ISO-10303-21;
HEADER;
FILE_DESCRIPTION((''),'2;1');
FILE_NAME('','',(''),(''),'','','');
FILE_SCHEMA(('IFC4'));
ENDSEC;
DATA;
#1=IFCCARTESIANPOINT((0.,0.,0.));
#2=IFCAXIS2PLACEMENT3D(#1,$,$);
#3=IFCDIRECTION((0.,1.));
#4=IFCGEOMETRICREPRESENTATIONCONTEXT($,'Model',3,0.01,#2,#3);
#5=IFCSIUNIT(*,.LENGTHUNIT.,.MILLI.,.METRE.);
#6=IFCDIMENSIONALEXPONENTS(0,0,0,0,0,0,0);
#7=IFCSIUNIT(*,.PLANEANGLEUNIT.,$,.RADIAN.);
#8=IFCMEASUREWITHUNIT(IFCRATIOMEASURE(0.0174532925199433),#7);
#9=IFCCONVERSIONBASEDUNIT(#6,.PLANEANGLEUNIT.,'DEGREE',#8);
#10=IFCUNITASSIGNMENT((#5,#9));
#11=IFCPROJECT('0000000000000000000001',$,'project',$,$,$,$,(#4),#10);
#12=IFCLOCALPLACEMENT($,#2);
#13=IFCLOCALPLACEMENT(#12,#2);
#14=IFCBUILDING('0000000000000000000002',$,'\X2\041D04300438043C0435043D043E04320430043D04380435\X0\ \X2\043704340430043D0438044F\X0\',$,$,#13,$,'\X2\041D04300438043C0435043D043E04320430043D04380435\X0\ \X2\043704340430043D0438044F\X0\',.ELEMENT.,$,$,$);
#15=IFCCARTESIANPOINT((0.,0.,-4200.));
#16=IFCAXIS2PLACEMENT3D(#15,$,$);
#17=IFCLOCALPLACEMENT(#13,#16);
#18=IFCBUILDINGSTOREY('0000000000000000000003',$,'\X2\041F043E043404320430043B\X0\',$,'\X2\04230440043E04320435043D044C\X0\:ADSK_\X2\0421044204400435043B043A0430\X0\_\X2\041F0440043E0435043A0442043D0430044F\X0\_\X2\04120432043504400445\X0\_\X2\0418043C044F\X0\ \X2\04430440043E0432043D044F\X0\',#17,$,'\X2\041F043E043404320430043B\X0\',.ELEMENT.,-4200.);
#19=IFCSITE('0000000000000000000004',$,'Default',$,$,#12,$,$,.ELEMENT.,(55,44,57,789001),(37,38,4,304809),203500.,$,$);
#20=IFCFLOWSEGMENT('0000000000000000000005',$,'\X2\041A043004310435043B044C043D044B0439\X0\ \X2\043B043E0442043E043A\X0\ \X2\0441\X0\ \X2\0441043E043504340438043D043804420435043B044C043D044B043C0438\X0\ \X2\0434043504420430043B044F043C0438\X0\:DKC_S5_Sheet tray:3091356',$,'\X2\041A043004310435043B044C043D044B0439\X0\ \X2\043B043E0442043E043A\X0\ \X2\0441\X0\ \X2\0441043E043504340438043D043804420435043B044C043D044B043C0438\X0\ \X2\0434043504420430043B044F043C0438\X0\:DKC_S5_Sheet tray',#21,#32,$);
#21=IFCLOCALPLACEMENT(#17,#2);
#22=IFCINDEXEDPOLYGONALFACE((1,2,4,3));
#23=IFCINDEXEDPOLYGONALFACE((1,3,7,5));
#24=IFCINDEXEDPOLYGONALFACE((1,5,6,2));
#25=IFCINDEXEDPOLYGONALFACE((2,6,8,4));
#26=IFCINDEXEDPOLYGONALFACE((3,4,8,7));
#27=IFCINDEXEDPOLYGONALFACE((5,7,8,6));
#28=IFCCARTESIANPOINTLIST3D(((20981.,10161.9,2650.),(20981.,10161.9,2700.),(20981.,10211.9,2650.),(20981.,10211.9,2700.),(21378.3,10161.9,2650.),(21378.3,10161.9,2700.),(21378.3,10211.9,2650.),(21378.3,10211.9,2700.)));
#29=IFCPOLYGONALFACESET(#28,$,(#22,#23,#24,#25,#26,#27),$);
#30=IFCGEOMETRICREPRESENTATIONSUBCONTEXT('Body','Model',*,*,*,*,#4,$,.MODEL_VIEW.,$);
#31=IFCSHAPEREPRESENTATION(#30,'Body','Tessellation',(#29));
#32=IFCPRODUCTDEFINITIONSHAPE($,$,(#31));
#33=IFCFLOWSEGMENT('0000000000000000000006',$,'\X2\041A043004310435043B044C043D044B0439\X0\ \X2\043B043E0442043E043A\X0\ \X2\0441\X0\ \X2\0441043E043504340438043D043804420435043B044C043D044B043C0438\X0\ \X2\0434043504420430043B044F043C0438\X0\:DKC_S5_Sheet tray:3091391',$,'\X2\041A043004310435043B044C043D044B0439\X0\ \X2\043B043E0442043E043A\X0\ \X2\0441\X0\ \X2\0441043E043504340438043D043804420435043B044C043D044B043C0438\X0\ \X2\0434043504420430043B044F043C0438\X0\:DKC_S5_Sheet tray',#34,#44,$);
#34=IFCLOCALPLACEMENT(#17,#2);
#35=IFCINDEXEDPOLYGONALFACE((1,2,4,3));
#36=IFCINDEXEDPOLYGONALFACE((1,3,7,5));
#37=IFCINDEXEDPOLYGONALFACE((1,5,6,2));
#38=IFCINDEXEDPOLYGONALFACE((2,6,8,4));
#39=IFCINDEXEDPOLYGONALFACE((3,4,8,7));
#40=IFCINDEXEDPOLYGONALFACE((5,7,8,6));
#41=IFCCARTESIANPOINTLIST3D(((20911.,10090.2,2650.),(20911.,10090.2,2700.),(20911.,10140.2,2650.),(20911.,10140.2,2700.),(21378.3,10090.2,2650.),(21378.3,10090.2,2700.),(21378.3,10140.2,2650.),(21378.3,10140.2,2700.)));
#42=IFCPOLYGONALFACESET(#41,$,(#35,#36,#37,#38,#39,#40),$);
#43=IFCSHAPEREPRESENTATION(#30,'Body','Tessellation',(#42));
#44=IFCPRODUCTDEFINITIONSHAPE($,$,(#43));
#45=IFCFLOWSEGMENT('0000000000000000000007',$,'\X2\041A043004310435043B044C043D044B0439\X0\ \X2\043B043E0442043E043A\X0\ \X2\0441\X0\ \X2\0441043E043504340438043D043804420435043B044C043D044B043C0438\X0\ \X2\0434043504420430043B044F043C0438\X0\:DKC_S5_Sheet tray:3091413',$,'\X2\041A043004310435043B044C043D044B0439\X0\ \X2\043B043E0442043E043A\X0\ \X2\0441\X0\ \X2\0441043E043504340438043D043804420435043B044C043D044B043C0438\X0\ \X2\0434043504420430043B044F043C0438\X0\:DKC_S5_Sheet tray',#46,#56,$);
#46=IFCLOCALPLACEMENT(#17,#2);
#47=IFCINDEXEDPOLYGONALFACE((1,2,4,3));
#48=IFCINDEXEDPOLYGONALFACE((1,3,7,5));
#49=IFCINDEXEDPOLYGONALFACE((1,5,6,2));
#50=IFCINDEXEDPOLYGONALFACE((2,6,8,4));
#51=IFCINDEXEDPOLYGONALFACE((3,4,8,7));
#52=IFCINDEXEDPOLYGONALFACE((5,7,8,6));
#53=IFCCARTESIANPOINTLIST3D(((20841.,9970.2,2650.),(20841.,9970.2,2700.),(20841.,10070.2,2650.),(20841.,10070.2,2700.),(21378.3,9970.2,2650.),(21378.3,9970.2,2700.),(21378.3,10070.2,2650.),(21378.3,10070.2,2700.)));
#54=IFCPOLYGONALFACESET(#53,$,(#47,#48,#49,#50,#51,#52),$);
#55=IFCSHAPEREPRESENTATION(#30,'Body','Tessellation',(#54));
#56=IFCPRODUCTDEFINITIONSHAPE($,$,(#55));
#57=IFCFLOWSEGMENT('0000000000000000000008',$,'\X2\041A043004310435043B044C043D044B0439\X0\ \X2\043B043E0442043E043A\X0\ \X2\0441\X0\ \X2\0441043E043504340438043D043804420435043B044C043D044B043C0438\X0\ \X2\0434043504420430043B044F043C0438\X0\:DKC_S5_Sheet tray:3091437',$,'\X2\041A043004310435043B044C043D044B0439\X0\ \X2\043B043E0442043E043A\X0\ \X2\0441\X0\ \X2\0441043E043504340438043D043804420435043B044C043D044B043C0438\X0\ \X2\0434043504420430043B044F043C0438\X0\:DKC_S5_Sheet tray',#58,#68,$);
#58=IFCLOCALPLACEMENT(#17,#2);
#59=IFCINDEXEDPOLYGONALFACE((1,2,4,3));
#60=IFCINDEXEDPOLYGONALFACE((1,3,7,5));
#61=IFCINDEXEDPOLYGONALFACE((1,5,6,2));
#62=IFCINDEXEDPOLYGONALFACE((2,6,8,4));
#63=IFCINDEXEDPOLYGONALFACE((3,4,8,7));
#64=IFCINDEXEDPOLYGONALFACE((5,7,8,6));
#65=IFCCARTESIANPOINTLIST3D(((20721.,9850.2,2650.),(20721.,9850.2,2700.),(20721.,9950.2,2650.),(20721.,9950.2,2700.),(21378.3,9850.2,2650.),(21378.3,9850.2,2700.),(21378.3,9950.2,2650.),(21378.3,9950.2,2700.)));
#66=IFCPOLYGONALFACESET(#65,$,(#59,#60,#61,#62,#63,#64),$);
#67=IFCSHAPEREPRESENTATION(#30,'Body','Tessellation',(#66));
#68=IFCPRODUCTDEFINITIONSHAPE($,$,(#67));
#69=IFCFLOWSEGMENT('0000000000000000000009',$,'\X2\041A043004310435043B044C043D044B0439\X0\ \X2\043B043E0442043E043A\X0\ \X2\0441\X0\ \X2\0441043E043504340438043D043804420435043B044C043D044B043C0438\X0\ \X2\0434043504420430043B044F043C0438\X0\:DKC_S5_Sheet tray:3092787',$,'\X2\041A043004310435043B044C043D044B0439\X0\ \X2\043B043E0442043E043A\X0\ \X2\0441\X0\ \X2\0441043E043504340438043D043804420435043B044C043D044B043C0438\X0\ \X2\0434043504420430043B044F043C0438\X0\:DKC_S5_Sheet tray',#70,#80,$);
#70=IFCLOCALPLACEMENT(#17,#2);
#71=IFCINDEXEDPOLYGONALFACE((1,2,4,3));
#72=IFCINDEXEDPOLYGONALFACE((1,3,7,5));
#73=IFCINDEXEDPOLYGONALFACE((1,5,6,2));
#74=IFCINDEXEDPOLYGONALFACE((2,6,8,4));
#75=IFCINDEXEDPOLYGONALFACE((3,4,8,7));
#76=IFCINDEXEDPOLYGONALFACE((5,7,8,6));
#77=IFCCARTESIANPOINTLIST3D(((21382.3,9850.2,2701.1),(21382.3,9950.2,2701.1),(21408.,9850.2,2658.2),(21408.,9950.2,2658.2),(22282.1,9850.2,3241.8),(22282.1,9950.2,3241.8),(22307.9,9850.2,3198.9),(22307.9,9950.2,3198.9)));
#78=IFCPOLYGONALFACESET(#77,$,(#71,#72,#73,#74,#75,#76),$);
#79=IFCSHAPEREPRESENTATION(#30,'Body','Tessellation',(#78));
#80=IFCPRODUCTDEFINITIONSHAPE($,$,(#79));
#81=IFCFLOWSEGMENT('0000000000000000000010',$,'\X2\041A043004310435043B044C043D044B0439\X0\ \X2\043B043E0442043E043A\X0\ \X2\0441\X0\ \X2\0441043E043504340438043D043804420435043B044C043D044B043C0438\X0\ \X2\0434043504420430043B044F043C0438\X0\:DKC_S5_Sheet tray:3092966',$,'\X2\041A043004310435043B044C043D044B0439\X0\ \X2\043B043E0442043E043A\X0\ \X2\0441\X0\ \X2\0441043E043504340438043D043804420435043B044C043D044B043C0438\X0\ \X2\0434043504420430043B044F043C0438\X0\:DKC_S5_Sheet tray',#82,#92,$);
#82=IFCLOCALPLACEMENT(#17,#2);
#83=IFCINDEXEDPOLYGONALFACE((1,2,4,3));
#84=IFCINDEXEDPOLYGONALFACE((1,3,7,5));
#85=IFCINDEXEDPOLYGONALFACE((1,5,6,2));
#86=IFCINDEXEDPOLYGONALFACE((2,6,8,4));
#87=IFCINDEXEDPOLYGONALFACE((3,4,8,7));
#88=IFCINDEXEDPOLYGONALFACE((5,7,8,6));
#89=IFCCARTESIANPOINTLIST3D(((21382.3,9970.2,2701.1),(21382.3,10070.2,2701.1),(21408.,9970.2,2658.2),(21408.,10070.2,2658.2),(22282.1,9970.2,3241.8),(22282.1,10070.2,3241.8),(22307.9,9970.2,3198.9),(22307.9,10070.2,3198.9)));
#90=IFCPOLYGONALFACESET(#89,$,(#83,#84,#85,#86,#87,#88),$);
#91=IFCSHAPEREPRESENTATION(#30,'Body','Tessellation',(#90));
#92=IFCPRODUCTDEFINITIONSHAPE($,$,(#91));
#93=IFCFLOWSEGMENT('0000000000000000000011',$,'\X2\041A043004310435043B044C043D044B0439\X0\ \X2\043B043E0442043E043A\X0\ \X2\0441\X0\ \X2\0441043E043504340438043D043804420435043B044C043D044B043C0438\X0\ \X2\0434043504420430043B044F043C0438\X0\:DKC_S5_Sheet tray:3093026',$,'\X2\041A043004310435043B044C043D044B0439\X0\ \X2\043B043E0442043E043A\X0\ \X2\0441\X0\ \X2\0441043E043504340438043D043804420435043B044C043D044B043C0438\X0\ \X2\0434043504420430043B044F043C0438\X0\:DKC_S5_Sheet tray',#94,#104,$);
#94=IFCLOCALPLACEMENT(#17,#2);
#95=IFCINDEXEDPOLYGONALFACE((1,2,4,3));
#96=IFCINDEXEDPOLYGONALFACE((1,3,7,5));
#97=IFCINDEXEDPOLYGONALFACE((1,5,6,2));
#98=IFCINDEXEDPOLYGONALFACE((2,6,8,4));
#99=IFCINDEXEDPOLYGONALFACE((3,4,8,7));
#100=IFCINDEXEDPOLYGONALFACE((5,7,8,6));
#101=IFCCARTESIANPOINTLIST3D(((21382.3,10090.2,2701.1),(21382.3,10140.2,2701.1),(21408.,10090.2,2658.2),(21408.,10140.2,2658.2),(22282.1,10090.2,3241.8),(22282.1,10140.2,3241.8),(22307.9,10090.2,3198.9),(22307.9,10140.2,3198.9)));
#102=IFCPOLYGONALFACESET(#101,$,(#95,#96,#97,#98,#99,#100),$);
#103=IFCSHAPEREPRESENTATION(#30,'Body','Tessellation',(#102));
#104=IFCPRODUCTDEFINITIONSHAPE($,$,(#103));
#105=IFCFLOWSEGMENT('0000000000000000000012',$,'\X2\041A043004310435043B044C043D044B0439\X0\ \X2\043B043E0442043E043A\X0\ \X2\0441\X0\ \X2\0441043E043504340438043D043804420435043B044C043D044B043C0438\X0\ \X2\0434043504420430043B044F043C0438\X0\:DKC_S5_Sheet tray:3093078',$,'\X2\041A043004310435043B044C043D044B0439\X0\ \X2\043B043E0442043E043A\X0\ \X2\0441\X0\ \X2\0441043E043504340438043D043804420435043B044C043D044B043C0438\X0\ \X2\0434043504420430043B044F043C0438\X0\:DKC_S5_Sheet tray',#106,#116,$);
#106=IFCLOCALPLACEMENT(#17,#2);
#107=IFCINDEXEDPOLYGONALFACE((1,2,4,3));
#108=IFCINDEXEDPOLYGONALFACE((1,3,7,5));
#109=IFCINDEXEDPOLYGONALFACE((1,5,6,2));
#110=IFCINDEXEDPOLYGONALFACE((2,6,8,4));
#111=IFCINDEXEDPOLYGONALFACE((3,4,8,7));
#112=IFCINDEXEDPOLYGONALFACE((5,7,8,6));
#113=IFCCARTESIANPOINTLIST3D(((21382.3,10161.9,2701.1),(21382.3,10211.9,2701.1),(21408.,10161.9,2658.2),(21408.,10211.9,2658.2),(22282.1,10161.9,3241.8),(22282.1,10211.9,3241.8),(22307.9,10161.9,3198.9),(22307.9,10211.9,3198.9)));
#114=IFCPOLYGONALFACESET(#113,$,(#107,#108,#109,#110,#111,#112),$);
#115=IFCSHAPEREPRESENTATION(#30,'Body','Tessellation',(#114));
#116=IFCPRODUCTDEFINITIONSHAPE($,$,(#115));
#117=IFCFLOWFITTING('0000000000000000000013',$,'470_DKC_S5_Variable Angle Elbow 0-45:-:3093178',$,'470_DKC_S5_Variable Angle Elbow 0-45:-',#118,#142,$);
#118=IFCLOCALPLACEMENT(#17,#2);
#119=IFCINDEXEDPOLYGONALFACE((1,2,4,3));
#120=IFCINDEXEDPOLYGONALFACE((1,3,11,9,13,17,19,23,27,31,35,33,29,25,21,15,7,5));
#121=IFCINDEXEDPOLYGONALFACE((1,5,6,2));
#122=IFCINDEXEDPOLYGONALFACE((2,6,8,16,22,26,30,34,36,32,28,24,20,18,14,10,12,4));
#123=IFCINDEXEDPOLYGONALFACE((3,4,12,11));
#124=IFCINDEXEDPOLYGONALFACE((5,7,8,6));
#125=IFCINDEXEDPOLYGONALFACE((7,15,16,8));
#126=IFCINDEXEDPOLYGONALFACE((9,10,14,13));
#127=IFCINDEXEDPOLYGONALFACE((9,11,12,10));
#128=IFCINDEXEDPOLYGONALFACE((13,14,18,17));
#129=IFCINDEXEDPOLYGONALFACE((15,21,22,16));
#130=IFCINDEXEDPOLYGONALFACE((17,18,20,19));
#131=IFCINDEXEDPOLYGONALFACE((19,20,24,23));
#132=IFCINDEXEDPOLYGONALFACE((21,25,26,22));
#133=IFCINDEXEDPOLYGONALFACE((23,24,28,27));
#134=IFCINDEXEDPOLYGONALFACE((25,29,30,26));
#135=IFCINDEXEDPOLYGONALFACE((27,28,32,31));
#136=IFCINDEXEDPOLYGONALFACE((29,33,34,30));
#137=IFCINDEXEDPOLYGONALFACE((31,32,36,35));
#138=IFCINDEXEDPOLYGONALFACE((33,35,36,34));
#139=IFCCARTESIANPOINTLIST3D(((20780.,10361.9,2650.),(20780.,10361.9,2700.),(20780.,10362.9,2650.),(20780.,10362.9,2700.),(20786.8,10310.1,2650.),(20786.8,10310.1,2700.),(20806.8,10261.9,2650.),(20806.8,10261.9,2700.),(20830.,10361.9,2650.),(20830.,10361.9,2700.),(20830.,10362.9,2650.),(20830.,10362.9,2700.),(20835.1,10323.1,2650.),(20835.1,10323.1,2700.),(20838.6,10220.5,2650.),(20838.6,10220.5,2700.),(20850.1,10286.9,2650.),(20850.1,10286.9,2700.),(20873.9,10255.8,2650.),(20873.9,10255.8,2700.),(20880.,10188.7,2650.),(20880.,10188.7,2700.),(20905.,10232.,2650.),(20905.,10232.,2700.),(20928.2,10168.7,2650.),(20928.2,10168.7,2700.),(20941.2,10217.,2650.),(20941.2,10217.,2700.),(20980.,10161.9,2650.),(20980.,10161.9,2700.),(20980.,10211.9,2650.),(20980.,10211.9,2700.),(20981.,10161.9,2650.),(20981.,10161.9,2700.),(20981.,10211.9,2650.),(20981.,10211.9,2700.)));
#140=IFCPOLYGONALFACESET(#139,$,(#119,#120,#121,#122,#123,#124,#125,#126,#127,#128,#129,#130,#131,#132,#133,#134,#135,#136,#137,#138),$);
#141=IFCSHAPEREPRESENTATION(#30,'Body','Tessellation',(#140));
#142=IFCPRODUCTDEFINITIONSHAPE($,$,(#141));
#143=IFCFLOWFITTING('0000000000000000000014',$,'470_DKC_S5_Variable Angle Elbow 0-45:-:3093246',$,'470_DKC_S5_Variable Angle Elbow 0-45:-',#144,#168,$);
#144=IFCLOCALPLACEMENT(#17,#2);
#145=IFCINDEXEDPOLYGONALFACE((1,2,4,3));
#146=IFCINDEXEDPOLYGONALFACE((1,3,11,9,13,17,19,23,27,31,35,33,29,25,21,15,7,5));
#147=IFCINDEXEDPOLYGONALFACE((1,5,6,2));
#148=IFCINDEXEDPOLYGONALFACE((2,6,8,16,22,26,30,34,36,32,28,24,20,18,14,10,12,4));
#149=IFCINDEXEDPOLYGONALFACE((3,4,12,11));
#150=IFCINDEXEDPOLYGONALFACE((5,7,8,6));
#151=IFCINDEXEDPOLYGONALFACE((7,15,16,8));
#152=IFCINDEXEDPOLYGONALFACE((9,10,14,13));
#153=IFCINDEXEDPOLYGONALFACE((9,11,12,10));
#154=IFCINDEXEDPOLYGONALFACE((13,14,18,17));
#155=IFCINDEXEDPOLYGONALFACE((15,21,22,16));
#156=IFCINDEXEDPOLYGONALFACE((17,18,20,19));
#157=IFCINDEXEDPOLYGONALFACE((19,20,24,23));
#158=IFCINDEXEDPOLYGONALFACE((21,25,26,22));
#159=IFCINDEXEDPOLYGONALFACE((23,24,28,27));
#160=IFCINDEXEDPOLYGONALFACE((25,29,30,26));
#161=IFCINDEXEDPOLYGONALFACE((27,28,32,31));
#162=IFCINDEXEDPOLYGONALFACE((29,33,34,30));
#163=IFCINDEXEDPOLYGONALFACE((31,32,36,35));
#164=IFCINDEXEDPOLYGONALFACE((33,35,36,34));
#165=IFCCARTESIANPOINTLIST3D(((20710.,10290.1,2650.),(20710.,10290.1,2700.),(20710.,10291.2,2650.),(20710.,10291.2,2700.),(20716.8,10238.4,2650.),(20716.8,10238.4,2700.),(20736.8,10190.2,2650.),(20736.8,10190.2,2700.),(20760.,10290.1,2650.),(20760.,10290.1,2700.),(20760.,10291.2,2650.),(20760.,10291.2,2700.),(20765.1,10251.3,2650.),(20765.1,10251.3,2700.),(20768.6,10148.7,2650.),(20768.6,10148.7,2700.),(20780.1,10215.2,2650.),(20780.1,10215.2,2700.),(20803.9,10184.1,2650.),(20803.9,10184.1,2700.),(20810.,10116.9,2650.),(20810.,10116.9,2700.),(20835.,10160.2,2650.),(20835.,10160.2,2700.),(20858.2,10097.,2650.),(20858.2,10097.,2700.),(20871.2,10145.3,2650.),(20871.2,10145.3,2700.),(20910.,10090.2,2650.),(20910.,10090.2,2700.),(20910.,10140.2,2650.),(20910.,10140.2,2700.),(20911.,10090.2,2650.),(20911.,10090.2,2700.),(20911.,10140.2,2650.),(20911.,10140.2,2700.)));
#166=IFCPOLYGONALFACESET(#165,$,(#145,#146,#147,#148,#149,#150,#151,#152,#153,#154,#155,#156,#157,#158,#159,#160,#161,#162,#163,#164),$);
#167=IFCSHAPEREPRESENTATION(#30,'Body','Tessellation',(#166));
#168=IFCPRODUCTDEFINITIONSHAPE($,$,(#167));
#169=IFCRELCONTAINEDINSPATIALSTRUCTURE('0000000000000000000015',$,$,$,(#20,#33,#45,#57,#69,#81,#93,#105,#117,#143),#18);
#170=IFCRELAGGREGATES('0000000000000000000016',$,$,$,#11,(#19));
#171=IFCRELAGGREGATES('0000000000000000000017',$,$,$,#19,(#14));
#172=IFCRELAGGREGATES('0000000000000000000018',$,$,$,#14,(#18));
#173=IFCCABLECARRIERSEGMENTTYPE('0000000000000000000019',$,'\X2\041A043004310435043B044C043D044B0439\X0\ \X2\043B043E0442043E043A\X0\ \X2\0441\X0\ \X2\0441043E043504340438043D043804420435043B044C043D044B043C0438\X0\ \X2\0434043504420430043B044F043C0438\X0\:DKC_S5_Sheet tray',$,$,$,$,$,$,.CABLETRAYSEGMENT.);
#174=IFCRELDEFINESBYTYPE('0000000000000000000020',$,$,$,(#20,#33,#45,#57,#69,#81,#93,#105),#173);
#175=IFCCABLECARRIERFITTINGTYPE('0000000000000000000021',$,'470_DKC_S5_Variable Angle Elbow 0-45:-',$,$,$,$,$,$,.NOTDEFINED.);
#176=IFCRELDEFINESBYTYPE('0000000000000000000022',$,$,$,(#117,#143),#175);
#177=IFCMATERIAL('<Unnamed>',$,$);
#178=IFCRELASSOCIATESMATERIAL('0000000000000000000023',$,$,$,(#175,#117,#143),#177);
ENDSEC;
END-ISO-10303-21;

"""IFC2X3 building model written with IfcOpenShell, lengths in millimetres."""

from ifc_helpers import new_model, entity, si_unit, converted_unit, direction, frame, frame_2d, origin, origin_2d_with_axis, place, context, subcontext, project, spatial, polyline, circle_curve, parameter, trimmed, segment, composite_curve, rectangle, outline, extrude, source, transform, mapped, material, type_object, type_shapes, element, save


model = new_model("IFC2X3")

# Units and contexts
model_context = context("Model", 3, precision=0.01, world=origin(), true_north=direction((0.0, 1.0)))
body_context = subcontext(model_context, "Body", "Model", "MODEL_VIEW")
ifc_project = project(units=[si_unit("LENGTHUNIT", "METRE", prefix="MILLI"), converted_unit("PLANEANGLEUNIT", "DEGREE", entity("IfcRatioMeasure", 0.0174532925199433), si_unit("PLANEANGLEUNIT", "RADIAN"), dimensions=[0, 0, 0, 0, 0, 0, 0])], contexts=[model_context])

# Site, building, storey
site_placement = place(None, origin())
site = spatial("IfcSite", under=ifc_project, at=site_placement, Name="Default", CompositionType="ELEMENT", RefLatitude=(55, 44, 57, 789001), RefLongitude=(37, 38, 4, 304809), RefElevation=203500.0)
building_placement = place(site_placement, origin())
building = spatial("IfcBuilding", under=site, at=building_placement, Name="Наименование здания", LongName="Наименование здания", CompositionType="ELEMENT")
storey_placement = place(building_placement, frame((0.0, 0.0, -4200.0)))
storey = spatial("IfcBuildingStorey", under=building, at=storey_placement, Name="Подвал", ObjectType="Уровень:ADSK_Стрелка_Проектная_Вверх_Имя уровня", LongName="Подвал", CompositionType="ELEMENT", Elevation=-4200.0)

# Flow segments
cable_carrier_segment_type = type_object("IfcCableCarrierSegmentType", Name="Кабельный лоток с соединительными деталями:DKC_S5_Sheet tray", PredefinedType="CABLETRAYSEGMENT")
flow_segment_1_placement = place(storey_placement, frame((20981.0, 10161.9, 2650.0)))
element("IfcFlowSegment", 1, at=flow_segment_1_placement, inside=storey, type_object=cable_carrier_segment_type, Name="Кабельный лоток с соединительными деталями:DKC_S5_Sheet tray:3091356", ObjectType="Кабельный лоток с соединительными деталями:DKC_S5_Sheet tray", context=body_context, shape_type="SweptSolid", body=[
    extrude(rectangle(XDim=397.3, YDim=50.0, at=origin_2d_with_axis()), frame((198.7, 25.0, 0.0)), (0.0, 0.0, 1.0), 50.0),
])
flow_segment_2_placement = place(storey_placement, frame((20911.0, 10090.1, 2650.0)))
element("IfcFlowSegment", 2, at=flow_segment_2_placement, inside=storey, type_object=cable_carrier_segment_type, Name="Кабельный лоток с соединительными деталями:DKC_S5_Sheet tray:3091391", ObjectType="Кабельный лоток с соединительными деталями:DKC_S5_Sheet tray", context=body_context, shape_type="SweptSolid", body=[
    extrude(rectangle(XDim=467.3, YDim=50.0, at=origin_2d_with_axis()), frame((233.7, 25.0, 0.0)), (0.0, 0.0, 1.0), 50.0),
])
flow_segment_3_placement = place(storey_placement, frame((20841.0, 9970.1, 2650.0)))
element("IfcFlowSegment", 3, at=flow_segment_3_placement, inside=storey, type_object=cable_carrier_segment_type, Name="Кабельный лоток с соединительными деталями:DKC_S5_Sheet tray:3091413", ObjectType="Кабельный лоток с соединительными деталями:DKC_S5_Sheet tray", context=body_context, shape_type="SweptSolid", body=[
    extrude(rectangle(XDim=537.3, YDim=100.0, at=origin_2d_with_axis()), frame((268.7, 50.0, 0.0)), (0.0, 0.0, 1.0), 50.0),
])
flow_segment_4_placement = place(storey_placement, frame((20721.0, 9850.1, 2650.0)))
element("IfcFlowSegment", 4, at=flow_segment_4_placement, inside=storey, type_object=cable_carrier_segment_type, Name="Кабельный лоток с соединительными деталями:DKC_S5_Sheet tray:3091437", ObjectType="Кабельный лоток с соединительными деталями:DKC_S5_Sheet tray", context=body_context, shape_type="SweptSolid", body=[
    extrude(rectangle(XDim=657.3, YDim=100.0, at=origin_2d_with_axis()), frame((328.7, 50.0, 0.0)), (0.0, 0.0, 1.0), 50.0),
])
flow_segment_5_placement = place(storey_placement, frame((21382.2, 9850.1, 2658.2)))
element("IfcFlowSegment", 5, at=flow_segment_5_placement, inside=storey, type_object=cable_carrier_segment_type, Name="Кабельный лоток с соединительными деталями:DKC_S5_Sheet tray:3092787", ObjectType="Кабельный лоток с соединительными деталями:DKC_S5_Sheet tray", context=body_context, shape_type="SweptSolid", body=[
    extrude(rectangle(XDim=50.0, YDim=100.0, at=origin_2d_with_axis()), frame((12.9, 50.0, 21.4), z_axis=(0.857167, 0.0, 0.515038), x_axis=(-0.515038, 0.0, 0.857167)), (0.0, 0.0, 1.0), 1049.8),
])
flow_segment_6_placement = place(storey_placement, frame((21382.2, 9970.1, 2658.2)))
element("IfcFlowSegment", 6, at=flow_segment_6_placement, inside=storey, type_object=cable_carrier_segment_type, Name="Кабельный лоток с соединительными деталями:DKC_S5_Sheet tray:3092966", ObjectType="Кабельный лоток с соединительными деталями:DKC_S5_Sheet tray", context=body_context, shape_type="SweptSolid", body=[
    extrude(rectangle(XDim=50.0, YDim=100.0, at=origin_2d_with_axis()), frame((12.9, 50.0, 21.4), z_axis=(0.857167, 0.0, 0.515038), x_axis=(-0.515038, 0.0, 0.857167)), (0.0, 0.0, 1.0), 1049.8),
])
for number, where, name in (
    (7, (21382.2, 10090.1, 2658.2), "Кабельный лоток с соединительными деталями:DKC_S5_Sheet tray:3093026"),
    (8, (21382.2, 10161.9, 2658.2), "Кабельный лоток с соединительными деталями:DKC_S5_Sheet tray:3093078"),
):
    element("IfcFlowSegment", number, at=place(storey_placement, frame(where)), inside=storey, type_object=cable_carrier_segment_type, Name=name, ObjectType="Кабельный лоток с соединительными деталями:DKC_S5_Sheet tray", context=body_context, shape_type="SweptSolid", body=[
        extrude(rectangle(XDim=50.0, YDim=50.0, at=origin_2d_with_axis()), frame((12.9, 25.0, 21.4), z_axis=(0.857167, 0.0, 0.515038), x_axis=(-0.515038, 0.0, 0.857167)), (0.0, 0.0, 1.0), 1049.8),
    ])

# Flow fittings
ifc_material_1 = material(Name="<Unnamed>")
cable_carrier_fitting_type_1 = type_object("IfcCableCarrierFittingType", Name="470_DKC_S5_Variable Angle Elbow 0-45:-", PredefinedType="NOTDEFINED", material=ifc_material_1)
shared_shape_1 = source(origin(), body_context, "Body", "SweptSolid", [
    extrude(outline(composite_curve([segment(polyline([(-88.2, -112.8), (-87.2, -112.8)]), True, "CONTINUOUS"), segment(trimmed(circle_curve(frame_2d((-87.2, 87.2), x_axis=(0.0, -1.0)), 200.0), [parameter(0.0)], [parameter(90.0)], True, "PARAMETER"), True, "CONTINUOUS"), segment(polyline([(112.8, 87.2), (112.8, 88.2)]), True, "CONTINUOUS"), segment(polyline([(112.8, 88.2), (62.8, 88.2)]), True, "CONTINUOUS"), segment(polyline([(62.8, 88.2), (62.8, 87.2)]), True, "CONTINUOUS"), segment(trimmed(circle_curve(frame_2d((-87.2, 87.2), x_axis=(0.0, -1.0)), 150.0), [parameter(0.0)], [parameter(90.0)], True, "PARAMETER"), False, "CONTINUOUS"), segment(polyline([(-87.2, -62.8), (-88.2, -62.8)]), True, "CONTINUOUS"), segment(polyline([(-88.2, -62.8), (-88.2, -112.8)]), True, "CONTINUOUS")], self_intersect=False)), frame((-87.8, 87.8, -25.0)), (0.0, 0.0, 1.0), 50.0),
])
type_shapes(cable_carrier_fitting_type_1, [shared_shape_1])
for number, where, z_axis, x_axis, name in (
    (9, (20805.0, 10186.9, 2675.0), (0.0, 0.0, 1.0), (0.0, -1.0, 0.0), "470_DKC_S5_Variable Angle Elbow 0-45:-:3093178"),
    (10, (20735.0, 10115.1, 2675.0), (0.0, 0.0, 1.0), (0.0, -1.0, 0.0), "470_DKC_S5_Variable Angle Elbow 0-45:-:3093246"),
):
    element("IfcFlowFitting", number, at=place(storey_placement, frame(where, z_axis=z_axis, x_axis=x_axis)), inside=storey, type_object=cable_carrier_fitting_type_1, material=ifc_material_1, Name=name, ObjectType="470_DKC_S5_Variable Angle Elbow 0-45:-", context=body_context, shape_type="MappedRepresentation", body=[
        mapped(shared_shape_1, transform((0.0, 0.0, 0.0), scale=1.0)),
    ])

save(model, "model.ifc")
